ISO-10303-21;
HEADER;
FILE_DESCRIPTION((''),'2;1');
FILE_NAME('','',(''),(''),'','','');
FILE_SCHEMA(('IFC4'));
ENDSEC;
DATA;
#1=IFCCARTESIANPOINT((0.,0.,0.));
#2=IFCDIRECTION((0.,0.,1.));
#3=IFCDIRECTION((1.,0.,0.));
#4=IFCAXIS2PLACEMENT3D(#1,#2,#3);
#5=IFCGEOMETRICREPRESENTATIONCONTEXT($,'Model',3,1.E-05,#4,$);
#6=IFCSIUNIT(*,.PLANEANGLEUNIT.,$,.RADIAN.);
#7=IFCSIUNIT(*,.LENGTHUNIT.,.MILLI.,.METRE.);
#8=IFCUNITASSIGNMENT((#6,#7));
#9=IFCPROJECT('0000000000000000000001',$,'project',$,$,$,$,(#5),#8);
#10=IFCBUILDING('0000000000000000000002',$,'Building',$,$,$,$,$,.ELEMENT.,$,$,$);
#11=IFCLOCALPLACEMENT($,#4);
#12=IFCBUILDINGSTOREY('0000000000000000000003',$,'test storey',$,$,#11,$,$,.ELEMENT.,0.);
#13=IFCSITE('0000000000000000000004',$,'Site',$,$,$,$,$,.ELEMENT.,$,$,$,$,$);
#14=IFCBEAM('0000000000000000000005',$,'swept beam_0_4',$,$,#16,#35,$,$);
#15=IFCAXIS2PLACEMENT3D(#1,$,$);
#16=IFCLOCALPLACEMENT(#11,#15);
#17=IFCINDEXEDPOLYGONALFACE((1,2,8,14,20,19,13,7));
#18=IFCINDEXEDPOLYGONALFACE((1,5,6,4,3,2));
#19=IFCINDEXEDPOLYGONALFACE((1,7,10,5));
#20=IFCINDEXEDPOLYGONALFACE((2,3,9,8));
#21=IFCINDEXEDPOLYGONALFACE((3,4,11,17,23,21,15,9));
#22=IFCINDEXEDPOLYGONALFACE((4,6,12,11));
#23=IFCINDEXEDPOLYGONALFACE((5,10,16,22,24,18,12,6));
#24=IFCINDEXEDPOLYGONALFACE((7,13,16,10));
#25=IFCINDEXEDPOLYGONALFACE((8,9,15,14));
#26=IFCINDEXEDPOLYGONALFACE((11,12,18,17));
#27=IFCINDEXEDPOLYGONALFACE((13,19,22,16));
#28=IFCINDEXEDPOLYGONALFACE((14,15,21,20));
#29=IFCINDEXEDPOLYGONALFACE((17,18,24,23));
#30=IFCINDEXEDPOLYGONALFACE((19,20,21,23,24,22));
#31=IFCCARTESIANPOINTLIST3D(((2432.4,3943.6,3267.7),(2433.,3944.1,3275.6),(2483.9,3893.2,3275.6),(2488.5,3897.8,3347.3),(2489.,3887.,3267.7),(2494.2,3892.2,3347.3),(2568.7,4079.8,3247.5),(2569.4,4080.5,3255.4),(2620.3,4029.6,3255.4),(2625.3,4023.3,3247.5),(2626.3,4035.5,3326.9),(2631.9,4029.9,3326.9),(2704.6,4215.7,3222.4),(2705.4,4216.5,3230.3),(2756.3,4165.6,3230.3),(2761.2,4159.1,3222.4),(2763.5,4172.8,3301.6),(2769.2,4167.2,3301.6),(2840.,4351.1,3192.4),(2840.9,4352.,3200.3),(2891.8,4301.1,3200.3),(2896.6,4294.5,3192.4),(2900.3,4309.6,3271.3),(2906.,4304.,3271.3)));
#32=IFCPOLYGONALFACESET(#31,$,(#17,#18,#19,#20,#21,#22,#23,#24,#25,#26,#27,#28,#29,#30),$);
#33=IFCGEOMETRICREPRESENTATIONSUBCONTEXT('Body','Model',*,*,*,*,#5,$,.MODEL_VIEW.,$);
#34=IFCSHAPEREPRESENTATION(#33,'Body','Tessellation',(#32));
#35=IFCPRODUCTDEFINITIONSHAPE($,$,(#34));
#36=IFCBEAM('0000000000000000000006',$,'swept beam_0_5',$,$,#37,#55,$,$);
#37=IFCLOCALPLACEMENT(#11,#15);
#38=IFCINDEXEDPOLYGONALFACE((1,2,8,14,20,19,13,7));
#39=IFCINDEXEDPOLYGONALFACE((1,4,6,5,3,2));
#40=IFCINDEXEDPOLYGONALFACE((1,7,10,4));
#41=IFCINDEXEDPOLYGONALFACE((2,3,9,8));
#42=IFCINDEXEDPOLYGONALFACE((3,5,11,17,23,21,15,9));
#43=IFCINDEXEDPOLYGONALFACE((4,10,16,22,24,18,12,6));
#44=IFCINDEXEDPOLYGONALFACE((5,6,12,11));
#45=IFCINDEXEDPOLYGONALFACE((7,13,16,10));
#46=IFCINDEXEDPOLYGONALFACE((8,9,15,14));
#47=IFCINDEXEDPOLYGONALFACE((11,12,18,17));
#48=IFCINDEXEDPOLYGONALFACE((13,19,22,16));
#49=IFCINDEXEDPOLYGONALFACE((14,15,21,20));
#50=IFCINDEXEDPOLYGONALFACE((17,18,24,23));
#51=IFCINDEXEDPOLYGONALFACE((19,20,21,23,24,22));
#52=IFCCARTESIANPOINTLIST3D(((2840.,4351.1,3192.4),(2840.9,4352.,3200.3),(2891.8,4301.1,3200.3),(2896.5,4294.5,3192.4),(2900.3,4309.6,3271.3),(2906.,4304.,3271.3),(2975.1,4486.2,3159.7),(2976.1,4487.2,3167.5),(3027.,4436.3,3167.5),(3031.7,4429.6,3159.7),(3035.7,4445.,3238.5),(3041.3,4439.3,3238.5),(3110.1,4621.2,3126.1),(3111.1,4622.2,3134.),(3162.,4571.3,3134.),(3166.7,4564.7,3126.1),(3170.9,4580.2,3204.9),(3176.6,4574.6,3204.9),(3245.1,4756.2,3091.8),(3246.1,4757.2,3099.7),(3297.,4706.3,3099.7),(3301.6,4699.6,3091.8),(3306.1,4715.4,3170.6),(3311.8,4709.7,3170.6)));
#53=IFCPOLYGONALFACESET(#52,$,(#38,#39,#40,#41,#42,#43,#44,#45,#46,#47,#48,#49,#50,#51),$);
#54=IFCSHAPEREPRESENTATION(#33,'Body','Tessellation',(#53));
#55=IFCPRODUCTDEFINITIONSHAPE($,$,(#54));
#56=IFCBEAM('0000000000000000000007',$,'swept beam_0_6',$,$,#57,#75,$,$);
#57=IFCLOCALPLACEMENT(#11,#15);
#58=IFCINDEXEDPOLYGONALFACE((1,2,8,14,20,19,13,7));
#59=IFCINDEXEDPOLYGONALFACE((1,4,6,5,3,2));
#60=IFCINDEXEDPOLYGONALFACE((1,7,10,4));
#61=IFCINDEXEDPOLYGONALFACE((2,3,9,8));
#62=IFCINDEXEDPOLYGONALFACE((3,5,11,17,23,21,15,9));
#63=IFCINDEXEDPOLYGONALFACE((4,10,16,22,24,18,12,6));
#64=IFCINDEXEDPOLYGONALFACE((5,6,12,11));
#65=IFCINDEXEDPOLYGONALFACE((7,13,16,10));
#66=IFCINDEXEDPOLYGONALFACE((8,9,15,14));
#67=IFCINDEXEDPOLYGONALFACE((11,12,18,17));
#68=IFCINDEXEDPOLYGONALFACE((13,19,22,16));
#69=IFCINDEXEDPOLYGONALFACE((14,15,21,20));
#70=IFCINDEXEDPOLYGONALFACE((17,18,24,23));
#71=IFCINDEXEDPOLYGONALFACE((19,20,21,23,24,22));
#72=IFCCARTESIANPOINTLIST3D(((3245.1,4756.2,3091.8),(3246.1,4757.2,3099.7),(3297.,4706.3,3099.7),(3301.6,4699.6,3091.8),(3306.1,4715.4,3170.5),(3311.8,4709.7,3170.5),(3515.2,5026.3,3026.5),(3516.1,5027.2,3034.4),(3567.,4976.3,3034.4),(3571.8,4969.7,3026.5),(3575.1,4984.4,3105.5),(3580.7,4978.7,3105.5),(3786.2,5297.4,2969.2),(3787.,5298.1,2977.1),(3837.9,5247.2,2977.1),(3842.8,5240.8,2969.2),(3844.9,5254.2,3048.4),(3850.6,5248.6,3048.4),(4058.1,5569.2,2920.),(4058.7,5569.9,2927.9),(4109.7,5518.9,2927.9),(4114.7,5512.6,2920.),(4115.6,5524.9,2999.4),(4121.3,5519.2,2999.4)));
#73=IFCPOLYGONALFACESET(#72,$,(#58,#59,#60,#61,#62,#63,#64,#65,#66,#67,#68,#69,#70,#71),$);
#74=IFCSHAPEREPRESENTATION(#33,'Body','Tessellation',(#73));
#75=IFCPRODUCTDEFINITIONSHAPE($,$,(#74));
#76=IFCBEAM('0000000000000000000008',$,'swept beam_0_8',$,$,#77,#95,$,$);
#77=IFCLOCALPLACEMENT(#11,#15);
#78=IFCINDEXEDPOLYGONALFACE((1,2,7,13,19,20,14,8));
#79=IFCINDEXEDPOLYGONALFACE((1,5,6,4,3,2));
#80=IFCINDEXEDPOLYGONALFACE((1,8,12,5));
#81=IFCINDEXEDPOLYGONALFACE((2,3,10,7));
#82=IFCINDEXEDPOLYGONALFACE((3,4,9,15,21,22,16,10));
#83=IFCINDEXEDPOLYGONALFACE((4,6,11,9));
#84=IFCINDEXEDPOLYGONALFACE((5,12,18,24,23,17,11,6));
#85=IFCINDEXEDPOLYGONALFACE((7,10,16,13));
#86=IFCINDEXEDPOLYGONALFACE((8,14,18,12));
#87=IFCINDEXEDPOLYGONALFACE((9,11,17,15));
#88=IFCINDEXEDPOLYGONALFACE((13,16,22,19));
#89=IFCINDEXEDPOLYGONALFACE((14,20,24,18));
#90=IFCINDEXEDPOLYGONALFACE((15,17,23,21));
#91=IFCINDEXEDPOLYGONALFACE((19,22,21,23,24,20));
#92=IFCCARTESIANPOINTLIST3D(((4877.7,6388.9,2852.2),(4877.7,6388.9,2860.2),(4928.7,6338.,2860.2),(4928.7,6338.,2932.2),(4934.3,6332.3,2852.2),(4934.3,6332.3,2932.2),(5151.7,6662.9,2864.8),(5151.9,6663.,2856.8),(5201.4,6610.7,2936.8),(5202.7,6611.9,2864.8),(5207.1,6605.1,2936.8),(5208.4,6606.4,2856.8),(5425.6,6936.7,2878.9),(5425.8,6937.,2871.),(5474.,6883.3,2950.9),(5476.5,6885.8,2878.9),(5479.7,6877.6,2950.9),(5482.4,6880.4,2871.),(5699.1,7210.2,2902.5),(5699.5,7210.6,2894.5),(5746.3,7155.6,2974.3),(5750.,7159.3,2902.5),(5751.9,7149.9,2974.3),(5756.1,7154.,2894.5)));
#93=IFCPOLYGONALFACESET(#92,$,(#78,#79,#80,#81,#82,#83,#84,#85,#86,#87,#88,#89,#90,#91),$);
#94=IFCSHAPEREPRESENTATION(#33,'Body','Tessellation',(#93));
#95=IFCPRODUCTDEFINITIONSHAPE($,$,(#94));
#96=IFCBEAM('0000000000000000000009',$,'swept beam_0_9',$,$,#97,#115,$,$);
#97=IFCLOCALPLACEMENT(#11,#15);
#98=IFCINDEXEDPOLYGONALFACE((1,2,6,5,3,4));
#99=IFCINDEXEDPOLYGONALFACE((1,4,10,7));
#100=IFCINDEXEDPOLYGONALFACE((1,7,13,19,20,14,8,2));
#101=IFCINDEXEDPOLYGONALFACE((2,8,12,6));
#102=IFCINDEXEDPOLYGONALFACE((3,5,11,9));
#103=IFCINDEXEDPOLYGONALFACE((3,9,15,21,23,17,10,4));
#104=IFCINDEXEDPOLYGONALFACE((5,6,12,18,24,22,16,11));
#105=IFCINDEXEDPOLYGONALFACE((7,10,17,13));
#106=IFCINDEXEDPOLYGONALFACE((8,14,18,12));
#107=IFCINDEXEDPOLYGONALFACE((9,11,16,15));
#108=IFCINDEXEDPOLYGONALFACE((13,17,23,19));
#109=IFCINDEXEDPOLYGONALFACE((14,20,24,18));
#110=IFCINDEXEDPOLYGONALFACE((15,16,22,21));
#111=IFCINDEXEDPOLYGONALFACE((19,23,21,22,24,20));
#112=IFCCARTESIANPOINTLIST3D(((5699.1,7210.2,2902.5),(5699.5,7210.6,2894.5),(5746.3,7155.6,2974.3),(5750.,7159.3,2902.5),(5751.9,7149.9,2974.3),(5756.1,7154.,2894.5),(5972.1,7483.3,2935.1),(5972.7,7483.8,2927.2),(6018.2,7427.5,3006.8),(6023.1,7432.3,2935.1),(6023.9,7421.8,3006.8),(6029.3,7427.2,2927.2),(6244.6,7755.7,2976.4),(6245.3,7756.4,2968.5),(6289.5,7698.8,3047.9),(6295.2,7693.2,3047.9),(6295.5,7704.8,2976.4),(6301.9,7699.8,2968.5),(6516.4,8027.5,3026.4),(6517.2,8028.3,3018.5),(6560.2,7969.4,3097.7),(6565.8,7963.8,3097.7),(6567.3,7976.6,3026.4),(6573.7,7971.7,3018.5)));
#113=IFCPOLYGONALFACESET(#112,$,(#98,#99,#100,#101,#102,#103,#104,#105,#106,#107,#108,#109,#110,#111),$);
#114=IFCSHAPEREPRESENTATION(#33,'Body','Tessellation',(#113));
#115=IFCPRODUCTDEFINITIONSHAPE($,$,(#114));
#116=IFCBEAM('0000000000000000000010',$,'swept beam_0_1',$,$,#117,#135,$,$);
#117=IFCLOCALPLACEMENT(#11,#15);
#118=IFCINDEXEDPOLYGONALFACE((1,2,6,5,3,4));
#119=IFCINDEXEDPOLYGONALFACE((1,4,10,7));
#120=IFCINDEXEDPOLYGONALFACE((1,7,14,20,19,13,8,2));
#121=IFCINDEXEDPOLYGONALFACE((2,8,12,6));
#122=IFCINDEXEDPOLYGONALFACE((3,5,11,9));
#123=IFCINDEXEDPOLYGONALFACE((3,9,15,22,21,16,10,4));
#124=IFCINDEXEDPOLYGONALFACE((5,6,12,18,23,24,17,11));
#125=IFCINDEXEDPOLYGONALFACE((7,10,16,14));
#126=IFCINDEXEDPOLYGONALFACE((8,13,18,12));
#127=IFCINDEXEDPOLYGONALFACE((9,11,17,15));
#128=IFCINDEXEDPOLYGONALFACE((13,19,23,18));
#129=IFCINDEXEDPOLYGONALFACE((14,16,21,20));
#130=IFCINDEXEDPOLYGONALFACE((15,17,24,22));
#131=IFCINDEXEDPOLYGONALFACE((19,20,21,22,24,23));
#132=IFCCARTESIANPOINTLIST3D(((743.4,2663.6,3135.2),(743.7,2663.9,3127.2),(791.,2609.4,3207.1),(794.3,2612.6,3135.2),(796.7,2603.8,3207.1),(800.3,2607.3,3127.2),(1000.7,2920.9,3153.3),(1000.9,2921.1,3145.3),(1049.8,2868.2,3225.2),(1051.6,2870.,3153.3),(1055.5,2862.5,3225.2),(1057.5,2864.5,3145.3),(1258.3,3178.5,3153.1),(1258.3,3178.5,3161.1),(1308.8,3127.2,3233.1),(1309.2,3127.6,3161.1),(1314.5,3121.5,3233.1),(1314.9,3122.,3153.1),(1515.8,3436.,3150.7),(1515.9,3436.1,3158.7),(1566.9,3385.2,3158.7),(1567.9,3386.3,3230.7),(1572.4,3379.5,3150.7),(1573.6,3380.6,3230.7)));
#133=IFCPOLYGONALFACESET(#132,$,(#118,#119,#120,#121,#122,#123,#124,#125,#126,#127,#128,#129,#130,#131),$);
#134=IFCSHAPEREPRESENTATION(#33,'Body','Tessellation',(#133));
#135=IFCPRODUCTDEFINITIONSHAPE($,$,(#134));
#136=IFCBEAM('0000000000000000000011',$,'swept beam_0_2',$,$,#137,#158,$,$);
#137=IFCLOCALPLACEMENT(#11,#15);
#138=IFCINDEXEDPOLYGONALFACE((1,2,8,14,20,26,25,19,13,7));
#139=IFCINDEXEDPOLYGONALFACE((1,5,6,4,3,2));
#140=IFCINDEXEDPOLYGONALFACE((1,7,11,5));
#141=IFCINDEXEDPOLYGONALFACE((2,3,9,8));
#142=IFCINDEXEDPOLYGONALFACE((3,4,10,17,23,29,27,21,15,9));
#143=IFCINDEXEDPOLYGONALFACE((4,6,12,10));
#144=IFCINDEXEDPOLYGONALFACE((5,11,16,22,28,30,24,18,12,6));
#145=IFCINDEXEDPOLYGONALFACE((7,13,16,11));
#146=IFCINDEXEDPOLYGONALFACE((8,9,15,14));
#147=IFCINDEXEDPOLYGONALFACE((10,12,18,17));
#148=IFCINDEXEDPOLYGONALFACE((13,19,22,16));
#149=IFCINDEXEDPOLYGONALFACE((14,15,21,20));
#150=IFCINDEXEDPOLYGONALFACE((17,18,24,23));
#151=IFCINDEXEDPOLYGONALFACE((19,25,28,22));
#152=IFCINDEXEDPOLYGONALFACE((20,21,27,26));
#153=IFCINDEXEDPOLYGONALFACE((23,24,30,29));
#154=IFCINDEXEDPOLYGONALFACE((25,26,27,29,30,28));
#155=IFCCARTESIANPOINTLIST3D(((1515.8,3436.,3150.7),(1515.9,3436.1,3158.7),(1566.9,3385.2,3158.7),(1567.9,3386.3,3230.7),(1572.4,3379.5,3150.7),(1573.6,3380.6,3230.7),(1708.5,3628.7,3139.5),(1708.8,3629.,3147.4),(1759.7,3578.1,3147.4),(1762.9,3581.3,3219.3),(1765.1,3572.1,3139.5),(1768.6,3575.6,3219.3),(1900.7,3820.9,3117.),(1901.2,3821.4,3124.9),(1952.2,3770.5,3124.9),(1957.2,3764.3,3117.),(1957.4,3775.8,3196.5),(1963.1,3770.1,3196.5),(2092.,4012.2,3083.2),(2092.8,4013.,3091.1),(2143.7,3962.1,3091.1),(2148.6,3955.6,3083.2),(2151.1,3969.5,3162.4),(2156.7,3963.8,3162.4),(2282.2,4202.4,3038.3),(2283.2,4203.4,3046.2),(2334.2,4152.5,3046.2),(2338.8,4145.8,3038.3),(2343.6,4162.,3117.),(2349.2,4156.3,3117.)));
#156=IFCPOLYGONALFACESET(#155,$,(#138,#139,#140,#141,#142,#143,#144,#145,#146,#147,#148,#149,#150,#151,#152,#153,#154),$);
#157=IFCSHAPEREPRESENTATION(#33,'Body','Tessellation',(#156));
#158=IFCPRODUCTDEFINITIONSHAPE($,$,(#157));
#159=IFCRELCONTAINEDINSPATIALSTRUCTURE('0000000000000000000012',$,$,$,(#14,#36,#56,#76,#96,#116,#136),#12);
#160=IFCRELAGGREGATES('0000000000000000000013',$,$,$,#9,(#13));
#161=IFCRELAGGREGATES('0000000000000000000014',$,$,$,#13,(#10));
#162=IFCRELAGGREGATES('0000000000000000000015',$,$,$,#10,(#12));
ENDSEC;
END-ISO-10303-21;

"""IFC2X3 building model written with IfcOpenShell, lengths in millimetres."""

from ifc_helpers import new_model, entity, si_unit, origin_with_axes, place, context, subcontext, project, spatial, element, save


model = new_model("IFC2X3")

# Units and contexts
model_context = context("Model", 3, precision=1e-05, world=origin_with_axes())
body_context = subcontext(model_context, "Body", "Model", "MODEL_VIEW")
ifc_project = project(units=[si_unit("PLANEANGLEUNIT", "RADIAN"), si_unit("LENGTHUNIT", "METRE", prefix="MILLI")], contexts=[model_context])

# Site, building, storey
site = spatial("IfcSite", under=ifc_project, Name="Site", CompositionType="ELEMENT")
building = spatial("IfcBuilding", under=site, Name="Building", CompositionType="ELEMENT")
storey_placement = place(None, origin_with_axes())
storey = spatial("IfcBuildingStorey", under=building, at=storey_placement, Name="test storey", CompositionType="ELEMENT", Elevation=0.0)

# Beams
beam_1_placement = place(storey_placement, origin_with_axes())
element("IfcBeam", 1, at=beam_1_placement, inside=storey, Name="swept beam_0_4", context=body_context, shape_type="SweptSolid", body=[
    entity("IfcRevolvedAreaSolid", entity("IfcArbitraryClosedProfileDef", "AREA", None, entity("IfcPolyline", [entity("IfcCartesianPoint", [80.0, -40.0]), entity("IfcCartesianPoint", [80.0, -32.0]), entity("IfcCartesianPoint", [8.0, -32.0]), entity("IfcCartesianPoint", [8.0, 40.0]), entity("IfcCartesianPoint", [0.0, 40.0]), entity("IfcCartesianPoint", [0.0, -40.0]), entity("IfcCartesianPoint", [80.0, -40.0])])), entity("IfcAxis2Placement3D", entity("IfcCartesianPoint", [2460.7, 3915.3, 3267.7]), entity("IfcDirection", [-0.7041, -0.7041, 0.0917]), entity("IfcDirection", [0.0649, 0.0649, 0.9958])), entity("IfcAxis1Placement", entity("IfcCartesianPoint", [-7653.3, 0.0, 0.0]), entity("IfcDirection", [0.0, 1.0, 0.0])), 0.075963),
])
beam_2_placement = place(storey_placement, origin_with_axes())
element("IfcBeam", 2, at=beam_2_placement, inside=storey, Name="swept beam_0_5", context=body_context, shape_type="SweptSolid", body=[
    entity("IfcRevolvedAreaSolid", entity("IfcArbitraryClosedProfileDef", "AREA", None, entity("IfcPolyline", [entity("IfcCartesianPoint", [80.0, -40.0]), entity("IfcCartesianPoint", [80.0, -32.0]), entity("IfcCartesianPoint", [8.0, -32.0]), entity("IfcCartesianPoint", [8.0, 40.0]), entity("IfcCartesianPoint", [0.0, 40.0]), entity("IfcCartesianPoint", [0.0, -40.0]), entity("IfcCartesianPoint", [80.0, -40.0])])), entity("IfcAxis2Placement3D", entity("IfcCartesianPoint", [2868.3, 4322.8, 3192.4]), entity("IfcDirection", [-0.6972, -0.6972, 0.167]), entity("IfcDirection", [0.1181, 0.1181, 0.986])), entity("IfcAxis1Placement", entity("IfcCartesianPoint", [-48381.5, 0.0, 0.0]), entity("IfcDirection", [0.0, 1.0, 0.0])), 0.012022),
])
beam_3_placement = place(storey_placement, origin_with_axes())
element("IfcBeam", 3, at=beam_3_placement, inside=storey, Name="swept beam_0_6", context=body_context, shape_type="SweptSolid", body=[
    entity("IfcRevolvedAreaSolid", entity("IfcArbitraryClosedProfileDef", "AREA", None, entity("IfcPolyline", [entity("IfcCartesianPoint", [-80.0, 40.0]), entity("IfcCartesianPoint", [-80.0, 32.0]), entity("IfcCartesianPoint", [-8.0, 32.0]), entity("IfcCartesianPoint", [-8.0, -40.0]), entity("IfcCartesianPoint", [0.0, -40.0]), entity("IfcCartesianPoint", [0.0, 40.0]), entity("IfcCartesianPoint", [-80.0, 40.0])])), entity("IfcAxis2Placement3D", entity("IfcCartesianPoint", [3273.3, 4727.9, 3091.8]), entity("IfcDirection", [-0.6957, -0.6957, 0.1789]), entity("IfcDirection", [-0.1265, -0.1265, -0.9839])), entity("IfcAxis1Placement", entity("IfcCartesianPoint", [-18450.9, 0.0, 0.0]), entity("IfcDirection", [0.0, 1.0, 0.0])), 0.063019),
])
beam_4_placement = place(storey_placement, origin_with_axes())
element("IfcBeam", 4, at=beam_4_placement, inside=storey, Name="swept beam_0_8", context=body_context, shape_type="SweptSolid", body=[
    entity("IfcRevolvedAreaSolid", entity("IfcArbitraryClosedProfileDef", "AREA", None, entity("IfcPolyline", [entity("IfcCartesianPoint", [-80.0, 40.0]), entity("IfcCartesianPoint", [-80.0, 32.0]), entity("IfcCartesianPoint", [-8.0, 32.0]), entity("IfcCartesianPoint", [-8.0, -40.0]), entity("IfcCartesianPoint", [0.0, -40.0]), entity("IfcCartesianPoint", [0.0, 40.0]), entity("IfcCartesianPoint", [-80.0, 40.0])])), entity("IfcAxis2Placement3D", entity("IfcCartesianPoint", [4906.0, 6360.6, 2852.2]), entity("IfcDirection", [-0.7071, -0.7071, 0.0001]), entity("IfcDirection", [0.0, 0.0, -1.0])), entity("IfcAxis1Placement", entity("IfcCartesianPoint", [-15930.0, 0.0, 0.0]), entity("IfcDirection", [0.0, 1.0, 0.0])), 0.073016),
])
beam_5_placement = place(storey_placement, origin_with_axes())
element("IfcBeam", 5, at=beam_5_placement, inside=storey, Name="swept beam_0_9", context=body_context, shape_type="SweptSolid", body=[
    entity("IfcRevolvedAreaSolid", entity("IfcArbitraryClosedProfileDef", "AREA", None, entity("IfcPolyline", [entity("IfcCartesianPoint", [-80.0, 40.0]), entity("IfcCartesianPoint", [-80.0, 32.0]), entity("IfcCartesianPoint", [-8.0, 32.0]), entity("IfcCartesianPoint", [-8.0, -40.0]), entity("IfcCartesianPoint", [0.0, -40.0]), entity("IfcCartesianPoint", [0.0, 40.0]), entity("IfcCartesianPoint", [-80.0, 40.0])])), entity("IfcAxis2Placement3D", entity("IfcCartesianPoint", [5727.8, 7182.3, 2894.5]), entity("IfcDirection", [-0.7052, -0.7052, -0.0729]), entity("IfcDirection", [0.0515, 0.0515, -0.9973])), entity("IfcAxis1Placement", entity("IfcCartesianPoint", [-17186.8, 0.0, 0.0]), entity("IfcDirection", [0.0, 1.0, 0.0])), 0.067681),
])
beam_6_placement = place(storey_placement, origin_with_axes())
element("IfcBeam", 6, at=beam_6_placement, inside=storey, Name="swept beam_0_1", context=body_context, shape_type="SweptSolid", body=[
    entity("IfcRevolvedAreaSolid", entity("IfcArbitraryClosedProfileDef", "AREA", None, entity("IfcPolyline", [entity("IfcCartesianPoint", [80.0, -40.0]), entity("IfcCartesianPoint", [80.0, -32.0]), entity("IfcCartesianPoint", [8.0, -32.0]), entity("IfcCartesianPoint", [8.0, 40.0]), entity("IfcCartesianPoint", [0.0, 40.0]), entity("IfcCartesianPoint", [0.0, -40.0]), entity("IfcCartesianPoint", [80.0, -40.0])])), entity("IfcAxis2Placement3D", entity("IfcCartesianPoint", [772.0, 2635.6, 3127.2]), entity("IfcDirection", [-0.7057, -0.7057, -0.0636]), entity("IfcDirection", [-0.0449, -0.0449, 0.998])), entity("IfcAxis1Placement", entity("IfcCartesianPoint", [-12972.9, 0.0, 0.0]), entity("IfcDirection", [0.0, 1.0, 0.0])), 0.084215),
])
beam_7_placement = place(storey_placement, origin_with_axes())
element("IfcBeam", 7, at=beam_7_placement, inside=storey, Name="swept beam_0_2", context=body_context, shape_type="SweptSolid", body=[
    entity("IfcRevolvedAreaSolid", entity("IfcArbitraryClosedProfileDef", "AREA", None, entity("IfcPolyline", [entity("IfcCartesianPoint", [80.0, -40.0]), entity("IfcCartesianPoint", [80.0, -32.0]), entity("IfcCartesianPoint", [8.0, -32.0]), entity("IfcCartesianPoint", [8.0, 40.0]), entity("IfcCartesianPoint", [0.0, 40.0]), entity("IfcCartesianPoint", [0.0, -40.0]), entity("IfcCartesianPoint", [80.0, -40.0])])), entity("IfcAxis2Placement3D", entity("IfcCartesianPoint", [1544.1, 3407.7, 3150.7]), entity("IfcDirection", [-0.707, -0.707, 0.0206]), entity("IfcDirection", [0.0146, 0.0146, 0.9998])), entity("IfcAxis1Placement", entity("IfcCartesianPoint", [-6594.2, 0.0, 0.0]), entity("IfcDirection", [0.0, 1.0, 0.0])), 0.165427),
])

save(model, "model.ifc")
